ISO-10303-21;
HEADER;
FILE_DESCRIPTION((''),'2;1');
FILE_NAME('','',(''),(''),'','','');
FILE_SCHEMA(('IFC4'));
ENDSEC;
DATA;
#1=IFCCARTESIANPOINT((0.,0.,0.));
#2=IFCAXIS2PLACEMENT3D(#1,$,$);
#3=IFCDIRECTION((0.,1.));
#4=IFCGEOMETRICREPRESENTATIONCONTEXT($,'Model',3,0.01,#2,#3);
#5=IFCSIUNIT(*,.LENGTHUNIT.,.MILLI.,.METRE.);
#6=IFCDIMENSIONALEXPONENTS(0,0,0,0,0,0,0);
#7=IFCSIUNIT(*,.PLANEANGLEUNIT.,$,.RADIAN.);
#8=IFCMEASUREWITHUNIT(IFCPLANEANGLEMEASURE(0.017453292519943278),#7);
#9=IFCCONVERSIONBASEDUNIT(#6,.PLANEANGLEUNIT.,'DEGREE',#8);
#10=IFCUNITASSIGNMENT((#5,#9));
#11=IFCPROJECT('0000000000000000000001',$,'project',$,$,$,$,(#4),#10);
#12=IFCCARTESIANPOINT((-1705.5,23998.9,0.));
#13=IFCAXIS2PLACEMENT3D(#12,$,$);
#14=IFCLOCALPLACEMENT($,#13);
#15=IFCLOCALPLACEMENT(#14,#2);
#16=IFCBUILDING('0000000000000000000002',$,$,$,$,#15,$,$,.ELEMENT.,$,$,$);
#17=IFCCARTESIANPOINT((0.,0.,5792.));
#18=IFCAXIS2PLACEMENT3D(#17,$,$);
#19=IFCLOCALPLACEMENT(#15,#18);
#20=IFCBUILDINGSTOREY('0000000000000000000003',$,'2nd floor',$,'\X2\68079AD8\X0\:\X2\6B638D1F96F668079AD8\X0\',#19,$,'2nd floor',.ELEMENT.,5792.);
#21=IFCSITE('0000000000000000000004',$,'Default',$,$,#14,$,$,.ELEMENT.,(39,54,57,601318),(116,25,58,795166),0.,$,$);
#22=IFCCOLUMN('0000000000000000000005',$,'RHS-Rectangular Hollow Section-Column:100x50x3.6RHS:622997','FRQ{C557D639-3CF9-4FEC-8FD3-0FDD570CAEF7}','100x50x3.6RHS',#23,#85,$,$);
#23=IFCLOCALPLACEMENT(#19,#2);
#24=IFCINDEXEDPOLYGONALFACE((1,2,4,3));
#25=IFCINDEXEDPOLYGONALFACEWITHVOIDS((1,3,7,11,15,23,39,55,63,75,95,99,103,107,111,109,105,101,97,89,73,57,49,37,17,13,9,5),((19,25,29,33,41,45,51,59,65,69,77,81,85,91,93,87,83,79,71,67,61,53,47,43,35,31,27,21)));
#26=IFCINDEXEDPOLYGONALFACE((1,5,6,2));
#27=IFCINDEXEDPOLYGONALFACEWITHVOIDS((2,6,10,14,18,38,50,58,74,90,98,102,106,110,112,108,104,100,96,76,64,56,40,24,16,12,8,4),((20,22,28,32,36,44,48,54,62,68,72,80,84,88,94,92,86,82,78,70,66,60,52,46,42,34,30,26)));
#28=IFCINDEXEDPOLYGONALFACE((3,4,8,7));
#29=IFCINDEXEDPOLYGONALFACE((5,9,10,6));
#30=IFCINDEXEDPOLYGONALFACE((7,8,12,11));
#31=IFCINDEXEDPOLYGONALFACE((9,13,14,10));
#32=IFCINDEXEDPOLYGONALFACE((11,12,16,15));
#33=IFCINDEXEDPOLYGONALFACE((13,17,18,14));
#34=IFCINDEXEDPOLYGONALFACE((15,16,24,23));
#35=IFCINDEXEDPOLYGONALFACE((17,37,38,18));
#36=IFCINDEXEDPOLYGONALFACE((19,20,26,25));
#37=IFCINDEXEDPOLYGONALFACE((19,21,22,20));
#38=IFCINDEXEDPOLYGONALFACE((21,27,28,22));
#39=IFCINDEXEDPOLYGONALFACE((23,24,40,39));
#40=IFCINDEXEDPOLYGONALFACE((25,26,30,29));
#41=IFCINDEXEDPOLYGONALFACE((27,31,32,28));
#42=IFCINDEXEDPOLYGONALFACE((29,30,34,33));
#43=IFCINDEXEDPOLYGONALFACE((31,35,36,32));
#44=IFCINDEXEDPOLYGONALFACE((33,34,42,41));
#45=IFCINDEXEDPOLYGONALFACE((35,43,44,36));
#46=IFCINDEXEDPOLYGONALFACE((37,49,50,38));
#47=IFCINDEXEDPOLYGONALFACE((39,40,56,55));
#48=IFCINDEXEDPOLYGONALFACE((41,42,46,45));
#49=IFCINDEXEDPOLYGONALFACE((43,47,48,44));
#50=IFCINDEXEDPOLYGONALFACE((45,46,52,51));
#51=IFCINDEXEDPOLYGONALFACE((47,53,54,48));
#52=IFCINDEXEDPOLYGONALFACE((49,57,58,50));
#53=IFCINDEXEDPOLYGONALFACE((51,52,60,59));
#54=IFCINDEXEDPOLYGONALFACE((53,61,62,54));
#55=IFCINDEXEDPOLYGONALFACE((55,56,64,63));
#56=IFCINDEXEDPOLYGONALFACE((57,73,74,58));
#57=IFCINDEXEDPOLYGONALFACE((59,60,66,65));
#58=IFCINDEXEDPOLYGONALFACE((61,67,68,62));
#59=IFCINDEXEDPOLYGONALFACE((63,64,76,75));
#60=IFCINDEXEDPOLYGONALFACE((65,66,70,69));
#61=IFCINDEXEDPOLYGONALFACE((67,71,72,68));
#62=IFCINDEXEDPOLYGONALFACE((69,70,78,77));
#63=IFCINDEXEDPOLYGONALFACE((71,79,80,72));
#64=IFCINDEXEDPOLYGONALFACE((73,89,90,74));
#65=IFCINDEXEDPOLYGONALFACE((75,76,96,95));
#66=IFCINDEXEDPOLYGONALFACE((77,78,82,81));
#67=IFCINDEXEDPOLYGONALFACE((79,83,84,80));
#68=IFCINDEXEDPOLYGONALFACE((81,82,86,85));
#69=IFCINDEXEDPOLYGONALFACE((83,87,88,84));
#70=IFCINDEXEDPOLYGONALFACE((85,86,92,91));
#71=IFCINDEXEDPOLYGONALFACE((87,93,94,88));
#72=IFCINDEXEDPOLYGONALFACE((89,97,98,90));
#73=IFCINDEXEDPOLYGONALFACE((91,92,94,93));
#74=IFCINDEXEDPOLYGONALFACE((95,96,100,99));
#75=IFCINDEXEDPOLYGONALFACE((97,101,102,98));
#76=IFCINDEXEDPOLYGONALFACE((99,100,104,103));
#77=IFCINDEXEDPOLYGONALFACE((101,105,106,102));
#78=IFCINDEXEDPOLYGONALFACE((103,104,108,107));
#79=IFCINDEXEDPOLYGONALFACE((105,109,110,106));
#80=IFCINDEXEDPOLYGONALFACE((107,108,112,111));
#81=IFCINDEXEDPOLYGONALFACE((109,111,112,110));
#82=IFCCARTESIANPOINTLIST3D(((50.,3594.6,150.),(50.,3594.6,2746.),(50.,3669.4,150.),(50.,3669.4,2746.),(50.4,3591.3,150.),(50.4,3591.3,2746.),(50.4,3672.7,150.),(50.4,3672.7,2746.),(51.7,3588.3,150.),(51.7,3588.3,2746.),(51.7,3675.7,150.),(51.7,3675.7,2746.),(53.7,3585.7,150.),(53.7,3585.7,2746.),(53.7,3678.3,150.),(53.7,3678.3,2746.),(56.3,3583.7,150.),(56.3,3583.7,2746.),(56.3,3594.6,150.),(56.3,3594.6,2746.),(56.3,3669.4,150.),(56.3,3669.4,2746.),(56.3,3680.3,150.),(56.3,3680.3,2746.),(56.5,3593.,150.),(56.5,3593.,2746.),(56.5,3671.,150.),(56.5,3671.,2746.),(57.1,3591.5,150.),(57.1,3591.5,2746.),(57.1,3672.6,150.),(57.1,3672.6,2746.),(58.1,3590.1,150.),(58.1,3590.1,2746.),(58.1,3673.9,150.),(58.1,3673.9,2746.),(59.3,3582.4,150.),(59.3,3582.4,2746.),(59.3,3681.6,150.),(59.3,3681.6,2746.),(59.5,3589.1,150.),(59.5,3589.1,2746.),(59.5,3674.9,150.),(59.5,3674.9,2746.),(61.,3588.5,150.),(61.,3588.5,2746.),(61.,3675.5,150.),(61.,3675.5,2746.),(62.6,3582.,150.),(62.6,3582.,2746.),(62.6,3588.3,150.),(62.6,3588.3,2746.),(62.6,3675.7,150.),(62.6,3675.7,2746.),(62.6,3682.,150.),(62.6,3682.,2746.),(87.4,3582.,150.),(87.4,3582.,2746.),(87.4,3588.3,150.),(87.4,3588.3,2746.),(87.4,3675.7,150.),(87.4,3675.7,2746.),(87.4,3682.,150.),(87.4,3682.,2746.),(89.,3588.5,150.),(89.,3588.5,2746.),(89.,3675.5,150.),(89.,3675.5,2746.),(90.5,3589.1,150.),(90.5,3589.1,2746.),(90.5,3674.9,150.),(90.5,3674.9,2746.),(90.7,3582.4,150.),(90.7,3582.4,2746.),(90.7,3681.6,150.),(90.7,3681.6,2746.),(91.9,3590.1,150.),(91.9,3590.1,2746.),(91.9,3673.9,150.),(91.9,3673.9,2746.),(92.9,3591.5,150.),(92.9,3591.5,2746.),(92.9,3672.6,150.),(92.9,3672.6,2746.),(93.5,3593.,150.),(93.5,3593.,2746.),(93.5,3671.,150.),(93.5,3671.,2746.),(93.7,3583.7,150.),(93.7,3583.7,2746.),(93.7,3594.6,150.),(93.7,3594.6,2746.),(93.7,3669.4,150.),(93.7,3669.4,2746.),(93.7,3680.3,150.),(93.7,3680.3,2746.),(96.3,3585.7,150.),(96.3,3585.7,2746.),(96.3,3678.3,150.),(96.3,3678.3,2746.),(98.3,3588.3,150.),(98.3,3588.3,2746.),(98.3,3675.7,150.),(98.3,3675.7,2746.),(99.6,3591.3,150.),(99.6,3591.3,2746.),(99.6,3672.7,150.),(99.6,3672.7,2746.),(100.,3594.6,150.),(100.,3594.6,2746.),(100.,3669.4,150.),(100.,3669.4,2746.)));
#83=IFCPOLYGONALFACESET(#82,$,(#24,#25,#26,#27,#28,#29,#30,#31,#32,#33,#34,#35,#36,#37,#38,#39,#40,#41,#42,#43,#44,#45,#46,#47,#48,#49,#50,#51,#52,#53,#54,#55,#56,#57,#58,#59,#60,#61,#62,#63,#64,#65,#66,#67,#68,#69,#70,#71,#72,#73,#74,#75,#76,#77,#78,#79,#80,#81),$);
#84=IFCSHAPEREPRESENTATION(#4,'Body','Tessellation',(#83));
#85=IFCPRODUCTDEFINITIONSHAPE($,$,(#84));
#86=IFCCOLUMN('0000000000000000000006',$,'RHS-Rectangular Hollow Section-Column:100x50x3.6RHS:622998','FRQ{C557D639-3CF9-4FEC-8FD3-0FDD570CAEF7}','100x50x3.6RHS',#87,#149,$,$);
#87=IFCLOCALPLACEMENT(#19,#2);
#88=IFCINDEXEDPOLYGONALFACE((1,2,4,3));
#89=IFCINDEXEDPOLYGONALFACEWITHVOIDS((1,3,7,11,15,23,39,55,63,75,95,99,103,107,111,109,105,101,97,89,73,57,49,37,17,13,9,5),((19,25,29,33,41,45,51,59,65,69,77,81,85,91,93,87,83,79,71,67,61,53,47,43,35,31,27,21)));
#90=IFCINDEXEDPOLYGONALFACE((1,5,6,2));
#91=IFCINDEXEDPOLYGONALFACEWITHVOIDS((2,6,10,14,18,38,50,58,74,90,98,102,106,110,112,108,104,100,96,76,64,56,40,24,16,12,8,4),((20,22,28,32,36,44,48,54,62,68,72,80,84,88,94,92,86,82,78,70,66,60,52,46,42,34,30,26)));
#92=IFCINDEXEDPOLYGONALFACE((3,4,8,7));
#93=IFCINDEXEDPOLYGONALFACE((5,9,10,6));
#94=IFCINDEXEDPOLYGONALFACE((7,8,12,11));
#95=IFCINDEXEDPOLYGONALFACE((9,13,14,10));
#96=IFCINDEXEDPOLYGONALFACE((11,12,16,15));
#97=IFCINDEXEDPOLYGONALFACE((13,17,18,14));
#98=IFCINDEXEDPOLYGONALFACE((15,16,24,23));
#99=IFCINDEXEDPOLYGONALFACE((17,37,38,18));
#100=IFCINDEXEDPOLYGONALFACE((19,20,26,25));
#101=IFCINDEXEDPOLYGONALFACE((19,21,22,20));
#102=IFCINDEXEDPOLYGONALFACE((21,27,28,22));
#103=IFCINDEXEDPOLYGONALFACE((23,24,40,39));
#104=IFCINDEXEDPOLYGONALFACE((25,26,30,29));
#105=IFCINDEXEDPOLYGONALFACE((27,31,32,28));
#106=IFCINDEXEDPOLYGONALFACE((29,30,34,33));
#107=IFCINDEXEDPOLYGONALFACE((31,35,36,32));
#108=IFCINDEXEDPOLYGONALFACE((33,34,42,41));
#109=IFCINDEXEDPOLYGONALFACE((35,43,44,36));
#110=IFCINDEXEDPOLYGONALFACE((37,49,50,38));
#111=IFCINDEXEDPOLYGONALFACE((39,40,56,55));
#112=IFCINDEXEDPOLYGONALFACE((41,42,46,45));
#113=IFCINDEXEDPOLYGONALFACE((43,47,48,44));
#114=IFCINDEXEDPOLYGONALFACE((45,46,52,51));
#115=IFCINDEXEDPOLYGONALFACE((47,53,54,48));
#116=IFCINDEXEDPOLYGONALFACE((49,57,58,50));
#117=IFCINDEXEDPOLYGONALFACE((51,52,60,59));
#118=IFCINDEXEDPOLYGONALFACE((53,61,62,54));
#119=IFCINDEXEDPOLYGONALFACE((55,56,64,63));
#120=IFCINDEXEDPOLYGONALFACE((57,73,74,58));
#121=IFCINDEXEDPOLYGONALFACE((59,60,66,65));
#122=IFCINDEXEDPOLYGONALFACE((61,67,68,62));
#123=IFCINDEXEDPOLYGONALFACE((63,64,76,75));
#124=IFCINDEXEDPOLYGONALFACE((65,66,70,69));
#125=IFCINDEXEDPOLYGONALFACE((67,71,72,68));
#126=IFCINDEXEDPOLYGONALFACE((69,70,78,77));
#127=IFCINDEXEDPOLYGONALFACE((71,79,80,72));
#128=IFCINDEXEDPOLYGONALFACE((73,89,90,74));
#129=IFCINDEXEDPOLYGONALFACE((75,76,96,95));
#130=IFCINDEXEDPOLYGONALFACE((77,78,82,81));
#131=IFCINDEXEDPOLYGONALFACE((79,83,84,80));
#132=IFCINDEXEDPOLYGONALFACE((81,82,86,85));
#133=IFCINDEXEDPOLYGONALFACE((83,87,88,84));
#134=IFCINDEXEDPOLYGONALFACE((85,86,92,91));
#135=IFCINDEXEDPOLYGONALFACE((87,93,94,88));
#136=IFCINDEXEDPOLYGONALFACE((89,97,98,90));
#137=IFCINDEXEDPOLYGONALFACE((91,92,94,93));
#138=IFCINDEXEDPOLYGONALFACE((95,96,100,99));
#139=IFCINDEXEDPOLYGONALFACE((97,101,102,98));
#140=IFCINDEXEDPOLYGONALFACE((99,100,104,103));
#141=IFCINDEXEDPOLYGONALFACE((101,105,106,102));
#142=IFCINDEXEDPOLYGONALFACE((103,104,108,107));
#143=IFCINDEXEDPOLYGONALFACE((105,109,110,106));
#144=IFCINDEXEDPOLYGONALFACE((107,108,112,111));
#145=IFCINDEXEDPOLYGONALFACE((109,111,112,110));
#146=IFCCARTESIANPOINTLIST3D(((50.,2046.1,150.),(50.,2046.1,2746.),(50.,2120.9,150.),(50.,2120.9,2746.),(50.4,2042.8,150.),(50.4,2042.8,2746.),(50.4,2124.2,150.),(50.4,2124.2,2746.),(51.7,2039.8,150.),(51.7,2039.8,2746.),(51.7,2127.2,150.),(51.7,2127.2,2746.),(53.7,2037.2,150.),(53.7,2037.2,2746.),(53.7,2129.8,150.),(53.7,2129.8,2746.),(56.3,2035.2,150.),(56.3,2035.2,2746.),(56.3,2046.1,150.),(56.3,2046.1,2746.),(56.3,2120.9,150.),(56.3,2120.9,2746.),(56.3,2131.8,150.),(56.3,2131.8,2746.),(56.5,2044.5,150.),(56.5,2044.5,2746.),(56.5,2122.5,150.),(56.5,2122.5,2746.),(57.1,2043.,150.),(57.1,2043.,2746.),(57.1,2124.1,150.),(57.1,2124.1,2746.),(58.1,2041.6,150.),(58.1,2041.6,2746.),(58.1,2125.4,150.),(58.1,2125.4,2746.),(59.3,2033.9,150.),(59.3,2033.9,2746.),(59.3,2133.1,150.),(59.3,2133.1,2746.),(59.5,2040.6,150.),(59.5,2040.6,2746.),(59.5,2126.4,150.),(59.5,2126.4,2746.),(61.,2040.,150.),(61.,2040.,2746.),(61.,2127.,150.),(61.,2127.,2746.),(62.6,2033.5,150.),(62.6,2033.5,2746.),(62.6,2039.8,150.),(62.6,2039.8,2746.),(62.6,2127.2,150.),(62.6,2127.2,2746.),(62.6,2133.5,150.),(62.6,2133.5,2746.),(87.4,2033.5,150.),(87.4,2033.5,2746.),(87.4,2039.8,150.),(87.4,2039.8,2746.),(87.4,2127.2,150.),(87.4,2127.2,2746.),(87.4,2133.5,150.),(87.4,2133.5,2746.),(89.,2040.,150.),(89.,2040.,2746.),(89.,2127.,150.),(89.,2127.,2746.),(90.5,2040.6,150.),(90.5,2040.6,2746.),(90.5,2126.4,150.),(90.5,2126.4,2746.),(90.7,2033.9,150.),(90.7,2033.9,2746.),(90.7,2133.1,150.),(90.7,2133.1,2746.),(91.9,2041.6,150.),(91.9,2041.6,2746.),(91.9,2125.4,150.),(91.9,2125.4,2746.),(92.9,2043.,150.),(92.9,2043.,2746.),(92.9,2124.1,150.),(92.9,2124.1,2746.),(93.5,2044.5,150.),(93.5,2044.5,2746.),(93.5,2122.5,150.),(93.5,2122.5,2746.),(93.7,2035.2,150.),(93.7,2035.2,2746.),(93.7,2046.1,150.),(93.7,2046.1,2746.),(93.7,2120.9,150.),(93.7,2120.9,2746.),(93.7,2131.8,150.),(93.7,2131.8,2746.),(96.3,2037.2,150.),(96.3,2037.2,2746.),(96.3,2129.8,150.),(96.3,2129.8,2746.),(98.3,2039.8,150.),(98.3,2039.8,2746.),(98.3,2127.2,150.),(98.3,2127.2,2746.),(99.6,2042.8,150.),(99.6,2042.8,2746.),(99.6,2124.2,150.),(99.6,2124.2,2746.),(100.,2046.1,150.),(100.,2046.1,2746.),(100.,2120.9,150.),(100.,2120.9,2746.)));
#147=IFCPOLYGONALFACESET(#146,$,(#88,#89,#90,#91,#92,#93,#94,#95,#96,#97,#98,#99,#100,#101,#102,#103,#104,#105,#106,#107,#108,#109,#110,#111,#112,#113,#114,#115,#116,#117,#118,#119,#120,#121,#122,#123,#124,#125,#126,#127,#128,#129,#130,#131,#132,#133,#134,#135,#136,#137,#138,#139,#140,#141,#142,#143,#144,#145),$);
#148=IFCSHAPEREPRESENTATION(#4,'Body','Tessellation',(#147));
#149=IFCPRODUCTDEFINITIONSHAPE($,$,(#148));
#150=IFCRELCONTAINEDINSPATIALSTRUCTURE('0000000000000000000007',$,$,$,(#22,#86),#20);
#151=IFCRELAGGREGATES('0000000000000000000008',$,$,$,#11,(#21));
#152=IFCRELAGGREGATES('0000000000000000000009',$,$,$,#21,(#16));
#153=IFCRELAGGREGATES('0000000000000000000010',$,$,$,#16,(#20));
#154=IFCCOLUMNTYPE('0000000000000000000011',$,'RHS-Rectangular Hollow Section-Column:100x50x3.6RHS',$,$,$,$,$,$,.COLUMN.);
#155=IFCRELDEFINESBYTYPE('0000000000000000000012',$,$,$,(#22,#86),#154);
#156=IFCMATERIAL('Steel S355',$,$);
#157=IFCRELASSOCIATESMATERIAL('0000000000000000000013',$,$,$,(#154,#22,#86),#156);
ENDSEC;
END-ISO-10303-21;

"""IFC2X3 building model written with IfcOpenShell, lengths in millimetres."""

from ifc_helpers import new_model, entity, si_unit, converted_unit, direction, frame, origin, origin_2d, place, context, project, spatial, hollow_rectangle, extrude, clip, halfspace, material, type_object, element, save


model = new_model("IFC2X3")

# Units and contexts
model_context = context("Model", 3, precision=0.01, world=origin(), true_north=direction((0.0, 1.0)))
ifc_project = project(units=[si_unit("LENGTHUNIT", "METRE", prefix="MILLI"), converted_unit("PLANEANGLEUNIT", "DEGREE", entity("IfcPlaneAngleMeasure", 0.017453292519943278), si_unit("PLANEANGLEUNIT", "RADIAN"), dimensions=[0, 0, 0, 0, 0, 0, 0])], contexts=[model_context])

# Site, building, storey
site_placement = place(None, frame((-1705.5, 23998.9, 0.0)))
site = spatial("IfcSite", under=ifc_project, at=site_placement, Name="Default", CompositionType="ELEMENT", RefLatitude=(39, 54, 57, 601318), RefLongitude=(116, 25, 58, 795166), RefElevation=0.0)
building_placement = place(site_placement, origin())
building = spatial("IfcBuilding", under=site, at=building_placement, CompositionType="ELEMENT")
storey_placement = place(building_placement, frame((0.0, 0.0, 5792.0)))
storey = spatial("IfcBuildingStorey", under=building, at=storey_placement, Name="2nd floor", ObjectType="标高:正负零标高", LongName="2nd floor", CompositionType="ELEMENT", Elevation=5792.0)

# Shared definitions
ifc_material_1 = material(Name="Steel S355")

# Columns
column_type_1 = type_object("IfcColumnType", Name="RHS-Rectangular Hollow Section-Column:100x50x3.6RHS", PredefinedType="COLUMN", material=ifc_material_1)
column_1_placement = place(storey_placement, frame((75.0, 3632.0, 2746.0), z_axis=(0.0, 0.0, 1.0), x_axis=(-1.0, 0.0, 0.0)))
element("IfcColumn", 1, at=column_1_placement, inside=storey, type_object=column_type_1, material=ifc_material_1, Name="RHS-Rectangular Hollow Section-Column:100x50x3.6RHS:622997", Description="FRQ{C557D639-3CF9-4FEC-8FD3-0FDD570CAEF7}", ObjectType="100x50x3.6RHS", context=model_context, shape_type="Clipping", body=[
    clip(extrude(hollow_rectangle(XDim=50.0, YDim=100.0, WallThickness=6.3, InnerFilletRadius=6.3, OuterFilletRadius=12.6, at=origin_2d()), origin(), (0.0, 0.0, -1.0), 2651.9), halfspace(frame((75.0, 3632.0, -2596.0), z_axis=(0.0, 0.0, 1.0), x_axis=(-1.0, 0.0, 0.0)), True)),
])
column_2_placement = place(storey_placement, frame((75.0, 2083.5, 2746.0), z_axis=(0.0, 0.0, 1.0), x_axis=(-1.0, 0.0, 0.0)))
element("IfcColumn", 2, at=column_2_placement, inside=storey, type_object=column_type_1, material=ifc_material_1, Name="RHS-Rectangular Hollow Section-Column:100x50x3.6RHS:622998", Description="FRQ{C557D639-3CF9-4FEC-8FD3-0FDD570CAEF7}", ObjectType="100x50x3.6RHS", context=model_context, shape_type="Clipping", body=[
    clip(extrude(hollow_rectangle(XDim=50.0, YDim=100.0, WallThickness=6.3, InnerFilletRadius=6.3, OuterFilletRadius=12.6, at=origin_2d()), origin(), (0.0, 0.0, -1.0), 2651.9), halfspace(frame((75.0, 2083.5, -2596.0), z_axis=(0.0, 0.0, 1.0), x_axis=(-1.0, 0.0, 0.0)), True)),
])

save(model, "model.ifc")
